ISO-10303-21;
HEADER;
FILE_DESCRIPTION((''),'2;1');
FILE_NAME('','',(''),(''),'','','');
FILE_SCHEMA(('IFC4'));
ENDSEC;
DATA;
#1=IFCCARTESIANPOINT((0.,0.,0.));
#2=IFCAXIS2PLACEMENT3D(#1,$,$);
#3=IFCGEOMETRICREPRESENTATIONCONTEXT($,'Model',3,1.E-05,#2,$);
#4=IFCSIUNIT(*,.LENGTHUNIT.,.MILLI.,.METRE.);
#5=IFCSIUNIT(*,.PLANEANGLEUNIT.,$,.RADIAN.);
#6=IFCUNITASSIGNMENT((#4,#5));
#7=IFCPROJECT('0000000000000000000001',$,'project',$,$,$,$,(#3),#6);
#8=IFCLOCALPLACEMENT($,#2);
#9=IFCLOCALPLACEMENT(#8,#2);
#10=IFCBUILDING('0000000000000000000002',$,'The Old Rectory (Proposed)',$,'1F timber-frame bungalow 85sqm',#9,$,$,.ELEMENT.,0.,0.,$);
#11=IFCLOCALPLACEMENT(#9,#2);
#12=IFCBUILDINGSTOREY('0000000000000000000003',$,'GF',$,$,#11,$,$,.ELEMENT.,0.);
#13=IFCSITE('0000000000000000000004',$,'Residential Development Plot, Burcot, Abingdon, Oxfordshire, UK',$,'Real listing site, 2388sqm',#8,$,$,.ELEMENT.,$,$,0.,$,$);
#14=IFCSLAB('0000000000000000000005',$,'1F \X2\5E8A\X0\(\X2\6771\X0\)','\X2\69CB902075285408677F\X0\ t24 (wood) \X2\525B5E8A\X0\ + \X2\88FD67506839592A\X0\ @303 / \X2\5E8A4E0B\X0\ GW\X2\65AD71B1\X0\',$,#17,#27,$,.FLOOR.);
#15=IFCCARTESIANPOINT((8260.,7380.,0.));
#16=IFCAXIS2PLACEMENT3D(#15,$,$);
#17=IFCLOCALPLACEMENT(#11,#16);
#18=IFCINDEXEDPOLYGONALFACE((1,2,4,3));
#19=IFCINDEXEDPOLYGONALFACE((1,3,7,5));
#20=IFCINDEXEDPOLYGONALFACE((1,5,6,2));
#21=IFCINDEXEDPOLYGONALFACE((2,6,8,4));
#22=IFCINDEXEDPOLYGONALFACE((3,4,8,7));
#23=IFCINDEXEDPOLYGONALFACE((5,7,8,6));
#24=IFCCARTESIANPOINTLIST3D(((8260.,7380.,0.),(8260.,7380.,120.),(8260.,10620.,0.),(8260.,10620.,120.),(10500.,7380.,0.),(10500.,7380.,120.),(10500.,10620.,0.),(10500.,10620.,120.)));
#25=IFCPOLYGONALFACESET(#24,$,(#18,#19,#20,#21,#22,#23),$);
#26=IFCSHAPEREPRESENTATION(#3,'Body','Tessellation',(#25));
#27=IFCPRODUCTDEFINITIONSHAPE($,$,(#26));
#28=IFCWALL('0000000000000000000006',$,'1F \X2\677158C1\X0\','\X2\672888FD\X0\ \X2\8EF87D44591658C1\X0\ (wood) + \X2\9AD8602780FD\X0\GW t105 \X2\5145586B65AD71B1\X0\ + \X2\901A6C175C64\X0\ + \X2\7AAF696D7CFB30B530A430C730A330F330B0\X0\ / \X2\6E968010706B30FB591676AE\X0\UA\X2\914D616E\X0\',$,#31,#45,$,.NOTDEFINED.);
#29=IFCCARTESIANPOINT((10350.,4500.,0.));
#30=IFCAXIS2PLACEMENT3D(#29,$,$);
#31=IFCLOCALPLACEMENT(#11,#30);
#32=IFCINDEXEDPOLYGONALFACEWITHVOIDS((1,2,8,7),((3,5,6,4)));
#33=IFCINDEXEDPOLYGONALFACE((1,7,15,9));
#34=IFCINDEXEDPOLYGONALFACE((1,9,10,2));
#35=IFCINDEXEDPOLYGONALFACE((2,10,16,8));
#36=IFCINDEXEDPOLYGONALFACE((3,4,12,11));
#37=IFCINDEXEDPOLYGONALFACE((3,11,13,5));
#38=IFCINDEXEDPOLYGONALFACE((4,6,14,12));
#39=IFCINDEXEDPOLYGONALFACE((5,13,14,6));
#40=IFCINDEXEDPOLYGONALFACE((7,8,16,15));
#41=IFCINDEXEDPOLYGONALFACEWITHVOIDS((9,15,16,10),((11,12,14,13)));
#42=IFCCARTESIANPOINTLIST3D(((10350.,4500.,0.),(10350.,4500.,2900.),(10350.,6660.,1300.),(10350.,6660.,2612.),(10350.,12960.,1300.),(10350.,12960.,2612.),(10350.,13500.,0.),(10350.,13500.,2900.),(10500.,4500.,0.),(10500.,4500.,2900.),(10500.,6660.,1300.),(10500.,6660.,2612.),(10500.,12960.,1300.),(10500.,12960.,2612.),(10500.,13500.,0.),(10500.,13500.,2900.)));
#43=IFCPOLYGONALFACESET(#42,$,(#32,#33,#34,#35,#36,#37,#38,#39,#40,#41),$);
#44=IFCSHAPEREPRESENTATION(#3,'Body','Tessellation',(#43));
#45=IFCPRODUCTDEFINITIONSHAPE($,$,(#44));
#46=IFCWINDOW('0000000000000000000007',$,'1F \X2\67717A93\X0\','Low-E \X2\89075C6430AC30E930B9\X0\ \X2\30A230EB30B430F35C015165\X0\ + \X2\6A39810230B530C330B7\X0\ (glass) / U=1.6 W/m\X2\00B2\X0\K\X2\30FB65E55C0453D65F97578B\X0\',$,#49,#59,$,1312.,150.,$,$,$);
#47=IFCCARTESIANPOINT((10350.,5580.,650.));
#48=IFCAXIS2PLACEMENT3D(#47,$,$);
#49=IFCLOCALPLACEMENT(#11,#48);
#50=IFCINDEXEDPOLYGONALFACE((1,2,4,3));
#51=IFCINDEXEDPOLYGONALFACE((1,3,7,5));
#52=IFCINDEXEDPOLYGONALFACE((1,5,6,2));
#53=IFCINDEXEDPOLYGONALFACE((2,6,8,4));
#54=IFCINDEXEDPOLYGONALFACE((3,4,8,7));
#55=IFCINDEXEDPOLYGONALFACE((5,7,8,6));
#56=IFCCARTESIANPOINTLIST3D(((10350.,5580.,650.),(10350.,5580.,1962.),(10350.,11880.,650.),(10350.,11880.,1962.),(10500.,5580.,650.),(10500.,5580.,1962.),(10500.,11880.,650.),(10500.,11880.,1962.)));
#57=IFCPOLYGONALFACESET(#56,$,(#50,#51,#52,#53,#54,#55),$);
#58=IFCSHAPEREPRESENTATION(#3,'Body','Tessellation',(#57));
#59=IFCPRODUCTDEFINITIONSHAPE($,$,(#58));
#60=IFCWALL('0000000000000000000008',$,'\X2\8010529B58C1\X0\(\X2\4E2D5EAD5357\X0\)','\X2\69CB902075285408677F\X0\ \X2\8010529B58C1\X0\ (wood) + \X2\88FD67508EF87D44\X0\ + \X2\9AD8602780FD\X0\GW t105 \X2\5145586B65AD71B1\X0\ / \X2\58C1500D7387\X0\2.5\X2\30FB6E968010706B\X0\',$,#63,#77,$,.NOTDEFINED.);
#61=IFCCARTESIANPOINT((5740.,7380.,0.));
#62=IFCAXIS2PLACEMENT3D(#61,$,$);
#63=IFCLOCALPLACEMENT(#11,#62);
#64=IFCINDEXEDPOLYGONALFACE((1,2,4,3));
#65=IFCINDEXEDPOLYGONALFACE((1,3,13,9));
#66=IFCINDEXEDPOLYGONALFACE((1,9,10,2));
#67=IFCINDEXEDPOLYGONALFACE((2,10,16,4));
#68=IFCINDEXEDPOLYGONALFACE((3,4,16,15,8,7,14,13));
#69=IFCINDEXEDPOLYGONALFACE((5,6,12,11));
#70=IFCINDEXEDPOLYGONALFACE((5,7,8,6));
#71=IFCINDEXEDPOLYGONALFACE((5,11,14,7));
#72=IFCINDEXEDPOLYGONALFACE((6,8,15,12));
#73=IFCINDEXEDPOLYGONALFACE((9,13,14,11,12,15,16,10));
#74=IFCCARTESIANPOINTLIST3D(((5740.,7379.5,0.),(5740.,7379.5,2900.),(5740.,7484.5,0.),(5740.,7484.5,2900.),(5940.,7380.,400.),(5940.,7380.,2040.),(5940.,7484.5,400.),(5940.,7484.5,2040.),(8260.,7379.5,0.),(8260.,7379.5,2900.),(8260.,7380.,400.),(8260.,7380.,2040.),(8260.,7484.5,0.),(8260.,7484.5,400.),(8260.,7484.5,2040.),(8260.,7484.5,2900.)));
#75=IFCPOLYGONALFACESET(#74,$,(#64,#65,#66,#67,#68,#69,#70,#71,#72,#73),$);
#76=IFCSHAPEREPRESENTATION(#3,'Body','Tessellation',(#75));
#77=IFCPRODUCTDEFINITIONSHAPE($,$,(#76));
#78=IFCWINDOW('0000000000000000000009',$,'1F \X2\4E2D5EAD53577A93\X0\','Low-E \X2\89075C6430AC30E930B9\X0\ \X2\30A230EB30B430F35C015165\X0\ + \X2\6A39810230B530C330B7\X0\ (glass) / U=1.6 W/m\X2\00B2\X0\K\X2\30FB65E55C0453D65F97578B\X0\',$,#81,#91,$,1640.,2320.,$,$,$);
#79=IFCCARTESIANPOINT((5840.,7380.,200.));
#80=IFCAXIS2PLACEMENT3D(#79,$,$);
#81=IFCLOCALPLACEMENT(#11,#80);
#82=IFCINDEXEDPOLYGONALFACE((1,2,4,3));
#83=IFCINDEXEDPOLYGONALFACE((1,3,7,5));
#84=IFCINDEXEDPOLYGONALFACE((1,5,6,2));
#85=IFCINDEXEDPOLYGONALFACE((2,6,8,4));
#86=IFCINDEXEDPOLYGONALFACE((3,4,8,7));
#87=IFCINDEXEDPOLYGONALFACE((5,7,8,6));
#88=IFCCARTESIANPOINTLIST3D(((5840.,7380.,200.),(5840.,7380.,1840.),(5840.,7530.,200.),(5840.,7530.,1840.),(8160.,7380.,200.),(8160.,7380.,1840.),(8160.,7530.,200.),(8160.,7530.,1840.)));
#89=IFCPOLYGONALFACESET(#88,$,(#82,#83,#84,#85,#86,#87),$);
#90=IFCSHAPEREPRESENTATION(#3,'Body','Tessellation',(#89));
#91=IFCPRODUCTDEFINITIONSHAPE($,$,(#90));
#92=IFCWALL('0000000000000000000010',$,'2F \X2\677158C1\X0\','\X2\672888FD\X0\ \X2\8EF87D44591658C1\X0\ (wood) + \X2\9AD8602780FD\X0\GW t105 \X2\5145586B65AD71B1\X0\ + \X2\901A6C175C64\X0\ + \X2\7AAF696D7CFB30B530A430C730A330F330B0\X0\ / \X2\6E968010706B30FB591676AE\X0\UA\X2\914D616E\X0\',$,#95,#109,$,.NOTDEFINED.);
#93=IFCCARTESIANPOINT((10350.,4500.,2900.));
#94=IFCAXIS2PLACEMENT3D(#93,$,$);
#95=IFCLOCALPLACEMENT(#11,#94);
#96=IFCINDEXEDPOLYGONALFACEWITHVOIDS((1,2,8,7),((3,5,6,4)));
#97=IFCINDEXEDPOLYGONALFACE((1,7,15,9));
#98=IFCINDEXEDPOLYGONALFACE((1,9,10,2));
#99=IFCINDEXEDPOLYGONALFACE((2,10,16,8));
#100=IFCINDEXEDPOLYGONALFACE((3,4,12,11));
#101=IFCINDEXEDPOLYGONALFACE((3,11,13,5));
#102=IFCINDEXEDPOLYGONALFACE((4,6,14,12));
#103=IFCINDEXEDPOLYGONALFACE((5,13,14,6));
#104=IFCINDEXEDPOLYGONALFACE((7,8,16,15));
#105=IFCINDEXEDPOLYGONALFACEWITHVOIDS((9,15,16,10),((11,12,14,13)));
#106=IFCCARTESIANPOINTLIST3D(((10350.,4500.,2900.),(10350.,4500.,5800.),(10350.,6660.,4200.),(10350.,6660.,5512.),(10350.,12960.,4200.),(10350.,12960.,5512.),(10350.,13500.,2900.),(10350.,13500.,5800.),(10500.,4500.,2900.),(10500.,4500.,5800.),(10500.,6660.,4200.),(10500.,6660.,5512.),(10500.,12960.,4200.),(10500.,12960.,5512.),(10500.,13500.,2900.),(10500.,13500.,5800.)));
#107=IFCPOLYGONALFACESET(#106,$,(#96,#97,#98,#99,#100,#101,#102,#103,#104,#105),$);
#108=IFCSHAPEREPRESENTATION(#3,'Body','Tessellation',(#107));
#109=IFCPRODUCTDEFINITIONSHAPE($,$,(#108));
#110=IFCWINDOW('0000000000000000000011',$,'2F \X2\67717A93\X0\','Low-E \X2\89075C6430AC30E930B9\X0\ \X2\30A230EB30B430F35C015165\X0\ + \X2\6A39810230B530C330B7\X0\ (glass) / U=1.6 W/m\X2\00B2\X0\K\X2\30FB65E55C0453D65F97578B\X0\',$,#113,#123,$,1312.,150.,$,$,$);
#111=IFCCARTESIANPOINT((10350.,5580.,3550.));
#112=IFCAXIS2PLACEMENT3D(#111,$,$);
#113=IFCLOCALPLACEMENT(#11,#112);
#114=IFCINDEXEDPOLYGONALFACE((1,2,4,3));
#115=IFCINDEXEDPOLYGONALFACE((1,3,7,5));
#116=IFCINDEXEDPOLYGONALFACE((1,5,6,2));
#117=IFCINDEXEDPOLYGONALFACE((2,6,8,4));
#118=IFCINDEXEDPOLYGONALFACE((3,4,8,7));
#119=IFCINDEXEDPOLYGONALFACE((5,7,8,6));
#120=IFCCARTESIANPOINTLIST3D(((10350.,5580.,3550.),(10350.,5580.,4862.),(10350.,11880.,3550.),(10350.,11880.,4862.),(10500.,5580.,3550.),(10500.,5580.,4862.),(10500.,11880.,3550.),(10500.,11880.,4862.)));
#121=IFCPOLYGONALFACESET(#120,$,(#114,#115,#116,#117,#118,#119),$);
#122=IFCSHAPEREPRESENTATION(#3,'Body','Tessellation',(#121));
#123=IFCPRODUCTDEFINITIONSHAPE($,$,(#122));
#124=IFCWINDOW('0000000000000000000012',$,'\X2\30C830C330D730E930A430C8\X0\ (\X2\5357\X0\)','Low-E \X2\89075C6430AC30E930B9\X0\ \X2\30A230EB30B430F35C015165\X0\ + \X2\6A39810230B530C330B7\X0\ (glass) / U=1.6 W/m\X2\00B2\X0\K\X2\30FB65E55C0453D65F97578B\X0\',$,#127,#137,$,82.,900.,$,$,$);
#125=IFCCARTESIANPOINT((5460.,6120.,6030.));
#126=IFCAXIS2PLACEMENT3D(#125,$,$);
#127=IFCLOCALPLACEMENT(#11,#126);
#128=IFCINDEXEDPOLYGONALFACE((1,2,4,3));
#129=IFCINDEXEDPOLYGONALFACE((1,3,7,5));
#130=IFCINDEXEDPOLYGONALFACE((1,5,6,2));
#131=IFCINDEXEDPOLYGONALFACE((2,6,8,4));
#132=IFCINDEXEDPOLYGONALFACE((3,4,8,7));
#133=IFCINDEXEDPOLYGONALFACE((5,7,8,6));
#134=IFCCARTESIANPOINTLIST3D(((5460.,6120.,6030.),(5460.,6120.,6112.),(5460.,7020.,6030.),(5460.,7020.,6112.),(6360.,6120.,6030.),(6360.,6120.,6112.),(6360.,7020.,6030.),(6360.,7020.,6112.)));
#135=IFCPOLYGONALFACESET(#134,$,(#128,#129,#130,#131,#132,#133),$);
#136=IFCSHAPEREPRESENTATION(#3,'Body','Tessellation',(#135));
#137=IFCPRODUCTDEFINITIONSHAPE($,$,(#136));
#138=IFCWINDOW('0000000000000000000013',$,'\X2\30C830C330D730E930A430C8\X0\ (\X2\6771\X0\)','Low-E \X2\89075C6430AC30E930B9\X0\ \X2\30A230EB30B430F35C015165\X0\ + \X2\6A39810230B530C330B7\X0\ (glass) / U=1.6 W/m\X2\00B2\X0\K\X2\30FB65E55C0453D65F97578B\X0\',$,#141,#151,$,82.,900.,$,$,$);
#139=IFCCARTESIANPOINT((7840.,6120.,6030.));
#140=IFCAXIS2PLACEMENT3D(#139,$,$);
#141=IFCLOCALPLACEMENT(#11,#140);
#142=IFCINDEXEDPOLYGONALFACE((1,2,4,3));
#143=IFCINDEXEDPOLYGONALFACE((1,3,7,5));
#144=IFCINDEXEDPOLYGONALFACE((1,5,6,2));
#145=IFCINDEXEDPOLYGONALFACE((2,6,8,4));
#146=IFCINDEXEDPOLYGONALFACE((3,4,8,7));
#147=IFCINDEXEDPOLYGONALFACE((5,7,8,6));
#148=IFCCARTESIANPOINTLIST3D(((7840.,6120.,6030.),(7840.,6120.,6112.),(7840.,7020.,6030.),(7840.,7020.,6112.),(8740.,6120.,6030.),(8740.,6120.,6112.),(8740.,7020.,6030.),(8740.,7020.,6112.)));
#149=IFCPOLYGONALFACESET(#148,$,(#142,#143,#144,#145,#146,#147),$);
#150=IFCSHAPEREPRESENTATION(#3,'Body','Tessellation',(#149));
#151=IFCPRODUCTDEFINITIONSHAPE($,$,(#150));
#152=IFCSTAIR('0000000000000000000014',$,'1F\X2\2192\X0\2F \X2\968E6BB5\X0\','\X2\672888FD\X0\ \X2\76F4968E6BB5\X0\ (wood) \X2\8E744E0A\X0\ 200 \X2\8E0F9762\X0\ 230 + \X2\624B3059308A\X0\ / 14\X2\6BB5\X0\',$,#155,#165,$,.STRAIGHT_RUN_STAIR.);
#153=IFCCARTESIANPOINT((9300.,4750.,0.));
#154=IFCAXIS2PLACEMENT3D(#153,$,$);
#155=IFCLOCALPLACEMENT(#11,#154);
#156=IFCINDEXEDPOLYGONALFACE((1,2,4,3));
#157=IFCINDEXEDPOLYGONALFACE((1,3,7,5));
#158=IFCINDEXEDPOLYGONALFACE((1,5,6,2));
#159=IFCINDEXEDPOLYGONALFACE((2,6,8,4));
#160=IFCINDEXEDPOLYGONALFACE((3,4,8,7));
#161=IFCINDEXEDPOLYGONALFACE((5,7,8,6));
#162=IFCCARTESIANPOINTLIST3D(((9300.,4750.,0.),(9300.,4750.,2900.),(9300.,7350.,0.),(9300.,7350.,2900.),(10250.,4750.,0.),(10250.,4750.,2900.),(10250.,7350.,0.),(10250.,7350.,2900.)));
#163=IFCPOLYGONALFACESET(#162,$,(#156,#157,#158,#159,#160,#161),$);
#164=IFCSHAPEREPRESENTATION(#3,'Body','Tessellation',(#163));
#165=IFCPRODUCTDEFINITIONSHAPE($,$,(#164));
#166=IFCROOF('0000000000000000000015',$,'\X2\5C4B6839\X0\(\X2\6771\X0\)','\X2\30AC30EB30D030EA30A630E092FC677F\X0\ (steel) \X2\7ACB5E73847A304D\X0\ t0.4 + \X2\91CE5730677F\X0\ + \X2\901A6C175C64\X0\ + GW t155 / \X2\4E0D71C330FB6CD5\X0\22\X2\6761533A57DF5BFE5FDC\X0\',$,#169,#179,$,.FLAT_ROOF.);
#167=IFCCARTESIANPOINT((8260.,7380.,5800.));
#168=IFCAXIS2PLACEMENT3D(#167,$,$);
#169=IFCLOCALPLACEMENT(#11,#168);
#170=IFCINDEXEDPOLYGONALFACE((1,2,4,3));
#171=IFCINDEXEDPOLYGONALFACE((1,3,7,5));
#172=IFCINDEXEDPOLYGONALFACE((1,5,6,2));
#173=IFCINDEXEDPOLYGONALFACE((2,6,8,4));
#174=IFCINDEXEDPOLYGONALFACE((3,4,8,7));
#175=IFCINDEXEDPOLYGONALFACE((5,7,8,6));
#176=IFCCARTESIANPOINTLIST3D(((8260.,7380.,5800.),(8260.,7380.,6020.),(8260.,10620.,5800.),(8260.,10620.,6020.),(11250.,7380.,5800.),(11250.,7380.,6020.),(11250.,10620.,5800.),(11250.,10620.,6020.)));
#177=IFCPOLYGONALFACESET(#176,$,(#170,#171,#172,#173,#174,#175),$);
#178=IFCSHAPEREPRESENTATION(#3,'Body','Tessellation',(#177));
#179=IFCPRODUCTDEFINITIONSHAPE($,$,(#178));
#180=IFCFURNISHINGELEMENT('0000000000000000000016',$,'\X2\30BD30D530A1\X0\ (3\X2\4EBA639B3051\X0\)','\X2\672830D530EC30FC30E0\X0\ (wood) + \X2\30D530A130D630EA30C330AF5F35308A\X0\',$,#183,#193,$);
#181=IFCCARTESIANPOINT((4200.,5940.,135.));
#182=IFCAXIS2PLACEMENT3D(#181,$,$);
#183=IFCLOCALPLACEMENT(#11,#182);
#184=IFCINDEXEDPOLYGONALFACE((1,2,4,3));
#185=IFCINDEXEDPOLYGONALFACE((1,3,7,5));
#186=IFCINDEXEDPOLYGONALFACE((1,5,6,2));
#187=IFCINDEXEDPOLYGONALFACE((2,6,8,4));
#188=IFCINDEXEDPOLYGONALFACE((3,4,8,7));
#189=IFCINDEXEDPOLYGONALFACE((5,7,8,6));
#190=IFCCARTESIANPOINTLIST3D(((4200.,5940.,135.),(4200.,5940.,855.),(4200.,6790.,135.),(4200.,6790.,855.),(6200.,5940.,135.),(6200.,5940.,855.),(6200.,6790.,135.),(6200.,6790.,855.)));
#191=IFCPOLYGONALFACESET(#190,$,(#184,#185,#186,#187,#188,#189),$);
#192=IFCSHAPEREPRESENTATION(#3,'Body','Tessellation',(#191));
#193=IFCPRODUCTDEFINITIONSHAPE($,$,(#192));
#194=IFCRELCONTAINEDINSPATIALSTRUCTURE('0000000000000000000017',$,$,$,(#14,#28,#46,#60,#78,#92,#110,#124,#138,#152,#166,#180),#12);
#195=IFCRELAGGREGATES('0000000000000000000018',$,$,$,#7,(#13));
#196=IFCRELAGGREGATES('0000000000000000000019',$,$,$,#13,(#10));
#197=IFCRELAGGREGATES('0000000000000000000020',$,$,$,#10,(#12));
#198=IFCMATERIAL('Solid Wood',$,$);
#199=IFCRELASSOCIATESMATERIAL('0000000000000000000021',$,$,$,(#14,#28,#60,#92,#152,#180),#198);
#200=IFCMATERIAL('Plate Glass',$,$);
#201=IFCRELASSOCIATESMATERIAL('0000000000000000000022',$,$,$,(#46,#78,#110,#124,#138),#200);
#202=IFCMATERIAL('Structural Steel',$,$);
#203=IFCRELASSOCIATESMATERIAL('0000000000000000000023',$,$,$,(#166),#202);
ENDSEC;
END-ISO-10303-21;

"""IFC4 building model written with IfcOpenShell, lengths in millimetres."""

from ifc_helpers import new_model, si_unit, frame, frame_2d, origin, place, context, project, spatial, rectangle, extrude, material, element, fill, save


model = new_model("IFC4")

# Units and contexts
model_context = context("Model", 3, precision=1e-05, world=origin())
ifc_project = project(units=[si_unit("LENGTHUNIT", "METRE", prefix="MILLI"), si_unit("PLANEANGLEUNIT", "RADIAN")], contexts=[model_context])

# Site, building, storey
site_placement = place(None, origin())
site = spatial("IfcSite", under=ifc_project, at=site_placement, Name="Residential Development Plot, Burcot, Abingdon, Oxfordshire, UK", ObjectType="Real listing site, 2388sqm", CompositionType="ELEMENT", RefElevation=0.0)
building_placement = place(site_placement, origin())
building = spatial("IfcBuilding", under=site, at=building_placement, Name="The Old Rectory (Proposed)", ObjectType="1F timber-frame bungalow 85sqm", CompositionType="ELEMENT", ElevationOfRefHeight=0.0, ElevationOfTerrain=0.0)
storey_placement = place(building_placement, origin())
storey = spatial("IfcBuildingStorey", under=building, at=storey_placement, Name="GF", CompositionType="ELEMENT", Elevation=0.0)

# Slab
ifc_material_1 = material(Name="Solid Wood")
slab_placement = place(storey_placement, frame((8260.0, 7380.0, 0.0)))
element("IfcSlab", 1, at=slab_placement, inside=storey, material=ifc_material_1, Name="1F 床(東)", Description="構造用合板 t24 (wood) 剛床 + 製材根太 @303 / 床下 GW断熱", PredefinedType="FLOOR", context=model_context, shape_type="SweptSolid", body=[
    extrude(rectangle(XDim=2240.0, YDim=3240.0, at=frame_2d((1120.0, 1620.0))), frame((8260.0, 7380.0, 0.0)), (0.0, 0.0, 1.0), 120.0),
])

# Walls, openings, windows
wall_1_placement = place(storey_placement, frame((10350.0, 4500.0, 0.0)))
wall_1 = element("IfcWall", 2, at=wall_1_placement, inside=storey, material=ifc_material_1, Name="1F 東壁", Description="木製 軸組外壁 (wood) + 高性能GW t105 充填断熱 + 通気層 + 窯業系サイディング / 準耐火・外皮UA配慮", PredefinedType="NOTDEFINED", context=model_context, shape_type="SweptSolid", body=[
    extrude(rectangle(XDim=150.0, YDim=9000.0, at=frame_2d((75.0, 4500.0))), frame((10350.0, 4500.0, 0.0)), (0.0, 0.0, 1.0), 2900.0),
])
opening_1_placement = place(storey_placement, frame((10350.0, 5580.0, 650.0)))
opening_1 = element("IfcOpeningElement", 3, at=opening_1_placement, cuts=wall_1, PredefinedType="NOTDEFINED", context=model_context, shape_type="SweptSolid", body=[
    extrude(rectangle(XDim=150.0, YDim=6300.0, at=frame_2d((75.0, 3150.0))), frame((10350.0, 5580.0, 650.0)), (0.0, 0.0, 1.0), 1312.0),
])
ifc_material_2 = material(Name="Plate Glass")
window_1_placement = place(storey_placement, frame((10350.0, 5580.0, 650.0)))
window_1 = element("IfcWindow", 4, at=window_1_placement, inside=storey, material=ifc_material_2, Name="1F 東窓", Description="Low-E 複層ガラス アルゴン封入 + 樹脂サッシ (glass) / U=1.6 W/m²K・日射取得型", OverallHeight=1312.0, OverallWidth=150.0, context=model_context, shape_type="SweptSolid", body=[
    extrude(rectangle(XDim=150.0, YDim=6300.0, at=frame_2d((75.0, 3150.0))), frame((10350.0, 5580.0, 650.0)), (0.0, 0.0, 1.0), 1312.0),
])
fill(opening_1, window_1)
wall_2_placement = place(storey_placement, frame((5740.0, 7380.0, 0.0)))
wall_2 = element("IfcWall", 5, at=wall_2_placement, inside=storey, material=ifc_material_1, Name="耐力壁(中庭南)", Description="構造用合板 耐力壁 (wood) + 製材軸組 + 高性能GW t105 充填断熱 / 壁倍率2.5・準耐火", PredefinedType="NOTDEFINED", context=model_context, shape_type="SweptSolid", body=[
    extrude(rectangle(XDim=2520.0, YDim=105.0, at=frame_2d((1260.0, 52.0))), frame((5740.0, 7380.0, 0.0)), (0.0, 0.0, 1.0), 2900.0),
])
opening_2_placement = place(storey_placement, frame((5840.0, 7380.0, 200.0)))
opening_2 = element("IfcOpeningElement", 6, at=opening_2_placement, cuts=wall_2, PredefinedType="NOTDEFINED", context=model_context, shape_type="SweptSolid", body=[
    extrude(rectangle(XDim=2320.0, YDim=150.0, at=frame_2d((1160.0, 75.0))), frame((5840.0, 7380.0, 200.0)), (0.0, 0.0, 1.0), 1640.0),
])
window_2_placement = place(storey_placement, frame((5840.0, 7380.0, 200.0)))
window_2 = element("IfcWindow", 7, at=window_2_placement, inside=storey, material=ifc_material_2, Name="1F 中庭南窓", Description="Low-E 複層ガラス アルゴン封入 + 樹脂サッシ (glass) / U=1.6 W/m²K・日射取得型", OverallHeight=1640.0, OverallWidth=2320.0, context=model_context, shape_type="SweptSolid", body=[
    extrude(rectangle(XDim=2320.0, YDim=150.0, at=frame_2d((1160.0, 75.0))), frame((5840.0, 7380.0, 200.0)), (0.0, 0.0, 1.0), 1640.0),
])
fill(opening_2, window_2)

# Wall, opening, window
wall_3_placement = place(storey_placement, frame((10350.0, 4500.0, 2900.0)))
wall_3 = element("IfcWall", 8, at=wall_3_placement, inside=storey, material=ifc_material_1, Name="2F 東壁", Description="木製 軸組外壁 (wood) + 高性能GW t105 充填断熱 + 通気層 + 窯業系サイディング / 準耐火・外皮UA配慮", PredefinedType="NOTDEFINED", context=model_context, shape_type="SweptSolid", body=[
    extrude(rectangle(XDim=150.0, YDim=9000.0, at=frame_2d((75.0, 4500.0))), frame((10350.0, 4500.0, 2900.0)), (0.0, 0.0, 1.0), 2900.0),
])
opening_3_placement = place(storey_placement, frame((10350.0, 5580.0, 3550.0)))
opening_3 = element("IfcOpeningElement", 9, at=opening_3_placement, cuts=wall_3, PredefinedType="NOTDEFINED", context=model_context, shape_type="SweptSolid", body=[
    extrude(rectangle(XDim=150.0, YDim=6300.0, at=frame_2d((75.0, 3150.0))), frame((10350.0, 5580.0, 3550.0)), (0.0, 0.0, 1.0), 1312.0),
])
window_3_placement = place(storey_placement, frame((10350.0, 5580.0, 3550.0)))
window_3 = element("IfcWindow", 10, at=window_3_placement, inside=storey, material=ifc_material_2, Name="2F 東窓", Description="Low-E 複層ガラス アルゴン封入 + 樹脂サッシ (glass) / U=1.6 W/m²K・日射取得型", OverallHeight=1312.0, OverallWidth=150.0, context=model_context, shape_type="SweptSolid", body=[
    extrude(rectangle(XDim=150.0, YDim=6300.0, at=frame_2d((75.0, 3150.0))), frame((10350.0, 5580.0, 3550.0)), (0.0, 0.0, 1.0), 1312.0),
])
fill(opening_3, window_3)

# Windows
window_4_placement = place(storey_placement, frame((5460.0, 6120.0, 6030.0)))
element("IfcWindow", 11, at=window_4_placement, inside=storey, material=ifc_material_2, Name="トップライト (南)", Description="Low-E 複層ガラス アルゴン封入 + 樹脂サッシ (glass) / U=1.6 W/m²K・日射取得型", OverallHeight=82.0, OverallWidth=900.0, context=model_context, shape_type="SweptSolid", body=[
    extrude(rectangle(XDim=900.0, YDim=900.0, at=frame_2d((450.0, 450.0))), frame((5460.0, 6120.0, 6030.0)), (0.0, 0.0, 1.0), 82.0),
])
window_5_placement = place(storey_placement, frame((7840.0, 6120.0, 6030.0)))
element("IfcWindow", 12, at=window_5_placement, inside=storey, material=ifc_material_2, Name="トップライト (東)", Description="Low-E 複層ガラス アルゴン封入 + 樹脂サッシ (glass) / U=1.6 W/m²K・日射取得型", OverallHeight=82.0, OverallWidth=900.0, context=model_context, shape_type="SweptSolid", body=[
    extrude(rectangle(XDim=900.0, YDim=900.0, at=frame_2d((450.0, 450.0))), frame((7840.0, 6120.0, 6030.0)), (0.0, 0.0, 1.0), 82.0),
])

# Stair
stair_placement = place(storey_placement, frame((9300.0, 4750.0, 0.0)))
element("IfcStair", 13, at=stair_placement, inside=storey, material=ifc_material_1, Name="1F→2F 階段", Description="木製 直階段 (wood) 蹴上 200 踏面 230 + 手すり / 14段", PredefinedType="STRAIGHT_RUN_STAIR", context=model_context, shape_type="SweptSolid", body=[
    extrude(rectangle(XDim=950.0, YDim=2600.0, at=frame_2d((475.0, 1300.0))), frame((9300.0, 4750.0, 0.0)), (0.0, 0.0, 1.0), 2900.0),
])

# Roof
ifc_material_3 = material(Name="Structural Steel")
roof_placement = place(storey_placement, frame((8260.0, 7380.0, 5800.0)))
element("IfcRoof", 14, at=roof_placement, inside=storey, material=ifc_material_3, Name="屋根(東)", Description="ガルバリウム鋼板 (steel) 立平葺き t0.4 + 野地板 + 通気層 + GW t155 / 不燃・法22条区域対応", PredefinedType="FLAT_ROOF", context=model_context, shape_type="SweptSolid", body=[
    extrude(rectangle(XDim=2990.0, YDim=3240.0, at=frame_2d((1495.0, 1620.0))), frame((8260.0, 7380.0, 5800.0)), (0.0, 0.0, 1.0), 220.0),
])

# Furnishing element
furnishing_1_placement = place(storey_placement, frame((4200.0, 5940.0, 135.0)))
element("IfcFurnishingElement", 15, at=furnishing_1_placement, inside=storey, material=ifc_material_1, Name="ソファ (3人掛け)", Description="木フレーム (wood) + ファブリック張り", context=model_context, shape_type="SweptSolid", body=[
    extrude(rectangle(XDim=2000.0, YDim=850.0, at=frame_2d((1000.0, 425.0))), frame((4200.0, 5940.0, 135.0)), (0.0, 0.0, 1.0), 720.0),
])

save(model, "model.ifc")
